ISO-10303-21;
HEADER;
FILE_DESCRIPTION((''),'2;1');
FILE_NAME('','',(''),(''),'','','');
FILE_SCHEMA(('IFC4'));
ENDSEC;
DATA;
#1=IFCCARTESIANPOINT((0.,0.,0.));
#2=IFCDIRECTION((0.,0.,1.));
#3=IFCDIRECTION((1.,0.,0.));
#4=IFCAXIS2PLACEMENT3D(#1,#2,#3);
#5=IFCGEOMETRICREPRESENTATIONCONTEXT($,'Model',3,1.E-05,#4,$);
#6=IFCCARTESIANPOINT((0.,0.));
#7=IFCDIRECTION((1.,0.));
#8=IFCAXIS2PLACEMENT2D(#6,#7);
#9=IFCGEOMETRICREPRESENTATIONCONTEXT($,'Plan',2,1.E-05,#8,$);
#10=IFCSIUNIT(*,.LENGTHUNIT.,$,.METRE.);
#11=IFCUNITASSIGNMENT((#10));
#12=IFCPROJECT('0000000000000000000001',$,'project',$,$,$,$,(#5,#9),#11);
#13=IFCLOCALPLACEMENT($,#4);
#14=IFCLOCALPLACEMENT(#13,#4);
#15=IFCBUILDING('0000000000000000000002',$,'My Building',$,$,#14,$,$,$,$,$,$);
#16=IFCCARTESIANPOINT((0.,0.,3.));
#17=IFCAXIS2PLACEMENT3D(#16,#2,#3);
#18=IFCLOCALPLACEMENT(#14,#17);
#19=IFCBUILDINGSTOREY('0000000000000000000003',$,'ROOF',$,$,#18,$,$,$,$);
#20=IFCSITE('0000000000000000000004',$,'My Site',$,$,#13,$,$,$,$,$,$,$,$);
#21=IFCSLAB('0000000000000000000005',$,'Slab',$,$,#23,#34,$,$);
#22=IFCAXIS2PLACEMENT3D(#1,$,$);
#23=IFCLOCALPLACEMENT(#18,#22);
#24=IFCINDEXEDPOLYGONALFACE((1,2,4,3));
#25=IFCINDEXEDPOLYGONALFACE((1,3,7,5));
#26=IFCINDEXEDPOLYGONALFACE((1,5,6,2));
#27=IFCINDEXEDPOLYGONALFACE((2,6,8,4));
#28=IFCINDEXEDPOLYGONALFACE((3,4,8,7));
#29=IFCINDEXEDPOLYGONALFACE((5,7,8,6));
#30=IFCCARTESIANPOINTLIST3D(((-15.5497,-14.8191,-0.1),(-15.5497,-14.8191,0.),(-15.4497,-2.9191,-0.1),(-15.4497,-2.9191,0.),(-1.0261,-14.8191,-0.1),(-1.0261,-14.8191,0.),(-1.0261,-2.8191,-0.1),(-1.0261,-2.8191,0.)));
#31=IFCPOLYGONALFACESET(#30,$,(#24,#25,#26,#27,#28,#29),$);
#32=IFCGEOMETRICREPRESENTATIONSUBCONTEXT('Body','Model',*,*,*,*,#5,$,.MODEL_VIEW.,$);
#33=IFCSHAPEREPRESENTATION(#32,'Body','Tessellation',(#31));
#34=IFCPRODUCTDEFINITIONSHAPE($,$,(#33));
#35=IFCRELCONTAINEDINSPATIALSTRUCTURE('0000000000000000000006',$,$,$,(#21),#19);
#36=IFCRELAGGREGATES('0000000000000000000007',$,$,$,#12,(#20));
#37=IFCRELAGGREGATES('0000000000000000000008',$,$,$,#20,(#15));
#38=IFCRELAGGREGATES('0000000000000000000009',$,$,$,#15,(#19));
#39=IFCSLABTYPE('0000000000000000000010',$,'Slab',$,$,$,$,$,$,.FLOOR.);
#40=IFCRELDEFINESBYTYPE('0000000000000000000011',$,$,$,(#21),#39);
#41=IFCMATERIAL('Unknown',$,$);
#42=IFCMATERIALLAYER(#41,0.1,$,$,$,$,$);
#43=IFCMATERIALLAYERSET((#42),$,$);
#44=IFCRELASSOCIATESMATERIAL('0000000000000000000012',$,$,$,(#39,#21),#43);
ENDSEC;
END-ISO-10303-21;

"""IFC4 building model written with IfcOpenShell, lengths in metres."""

from ifc_helpers import new_model, si_unit, frame, origin_with_axes, origin_2d_with_axis, place, context, subcontext, project, spatial, indexed_curve, outline, extrude, material, layer, layer_set, layer_usage, type_object, element, save


model = new_model("IFC4")

# Units and contexts
model_context = context("Model", 3, precision=1e-05, world=origin_with_axes())
plan_context = context("Plan", 2, precision=1e-05, world=origin_2d_with_axis())
body_context = subcontext(model_context, "Body", "Model", "MODEL_VIEW")
ifc_project = project(units=[si_unit("LENGTHUNIT", "METRE")], contexts=[model_context, plan_context])

# Site, building, storey
site_placement = place(None, origin_with_axes())
site = spatial("IfcSite", under=ifc_project, at=site_placement, Name="My Site")
building_placement = place(site_placement, origin_with_axes())
building = spatial("IfcBuilding", under=site, at=building_placement, Name="My Building")
storey_placement = place(building_placement, frame((0.0, 0.0, 3.0), z_axis=(0.0, 0.0, 1.0), x_axis=(1.0, 0.0, 0.0)))
storey = spatial("IfcBuildingStorey", under=building, at=storey_placement, Name="ROOF")

# Slab
ifc_material = material(Name="Unknown")
ifc_layer = layer(ifc_material, 0.1)
ifc_layer_set = layer_set([ifc_layer])
ifc_layer_usage = layer_usage(ifc_layer_set, "AXIS3", "POSITIVE", -0.1)
slab_type = type_object("IfcSlabType", Name="Slab", PredefinedType="FLOOR", material=ifc_layer_set)
slab_placement = place(storey_placement, frame((-15.4497, -2.9191, 0.0), z_axis=(0.0, 0.0, 1.0), x_axis=(1.0, 0.0, 0.0)))
element("IfcSlab", 1, at=slab_placement, inside=storey, type_object=slab_type, material=ifc_layer_usage, Name="Slab", context=body_context, shape_type="SweptSolid", body=[
    extrude(outline(indexed_curve([(0.0, 0.0), (14.4236, 0.1), (14.4236, -11.9), (-0.1, -11.9), (0.0, 0.0)])), frame((0.0, 0.0, -0.1), z_axis=(0.0, 0.0, 1.0), x_axis=(1.0, 0.0, 0.0)), (0.0, 0.0, 1.0), 0.1),
])

save(model, "model.ifc")
